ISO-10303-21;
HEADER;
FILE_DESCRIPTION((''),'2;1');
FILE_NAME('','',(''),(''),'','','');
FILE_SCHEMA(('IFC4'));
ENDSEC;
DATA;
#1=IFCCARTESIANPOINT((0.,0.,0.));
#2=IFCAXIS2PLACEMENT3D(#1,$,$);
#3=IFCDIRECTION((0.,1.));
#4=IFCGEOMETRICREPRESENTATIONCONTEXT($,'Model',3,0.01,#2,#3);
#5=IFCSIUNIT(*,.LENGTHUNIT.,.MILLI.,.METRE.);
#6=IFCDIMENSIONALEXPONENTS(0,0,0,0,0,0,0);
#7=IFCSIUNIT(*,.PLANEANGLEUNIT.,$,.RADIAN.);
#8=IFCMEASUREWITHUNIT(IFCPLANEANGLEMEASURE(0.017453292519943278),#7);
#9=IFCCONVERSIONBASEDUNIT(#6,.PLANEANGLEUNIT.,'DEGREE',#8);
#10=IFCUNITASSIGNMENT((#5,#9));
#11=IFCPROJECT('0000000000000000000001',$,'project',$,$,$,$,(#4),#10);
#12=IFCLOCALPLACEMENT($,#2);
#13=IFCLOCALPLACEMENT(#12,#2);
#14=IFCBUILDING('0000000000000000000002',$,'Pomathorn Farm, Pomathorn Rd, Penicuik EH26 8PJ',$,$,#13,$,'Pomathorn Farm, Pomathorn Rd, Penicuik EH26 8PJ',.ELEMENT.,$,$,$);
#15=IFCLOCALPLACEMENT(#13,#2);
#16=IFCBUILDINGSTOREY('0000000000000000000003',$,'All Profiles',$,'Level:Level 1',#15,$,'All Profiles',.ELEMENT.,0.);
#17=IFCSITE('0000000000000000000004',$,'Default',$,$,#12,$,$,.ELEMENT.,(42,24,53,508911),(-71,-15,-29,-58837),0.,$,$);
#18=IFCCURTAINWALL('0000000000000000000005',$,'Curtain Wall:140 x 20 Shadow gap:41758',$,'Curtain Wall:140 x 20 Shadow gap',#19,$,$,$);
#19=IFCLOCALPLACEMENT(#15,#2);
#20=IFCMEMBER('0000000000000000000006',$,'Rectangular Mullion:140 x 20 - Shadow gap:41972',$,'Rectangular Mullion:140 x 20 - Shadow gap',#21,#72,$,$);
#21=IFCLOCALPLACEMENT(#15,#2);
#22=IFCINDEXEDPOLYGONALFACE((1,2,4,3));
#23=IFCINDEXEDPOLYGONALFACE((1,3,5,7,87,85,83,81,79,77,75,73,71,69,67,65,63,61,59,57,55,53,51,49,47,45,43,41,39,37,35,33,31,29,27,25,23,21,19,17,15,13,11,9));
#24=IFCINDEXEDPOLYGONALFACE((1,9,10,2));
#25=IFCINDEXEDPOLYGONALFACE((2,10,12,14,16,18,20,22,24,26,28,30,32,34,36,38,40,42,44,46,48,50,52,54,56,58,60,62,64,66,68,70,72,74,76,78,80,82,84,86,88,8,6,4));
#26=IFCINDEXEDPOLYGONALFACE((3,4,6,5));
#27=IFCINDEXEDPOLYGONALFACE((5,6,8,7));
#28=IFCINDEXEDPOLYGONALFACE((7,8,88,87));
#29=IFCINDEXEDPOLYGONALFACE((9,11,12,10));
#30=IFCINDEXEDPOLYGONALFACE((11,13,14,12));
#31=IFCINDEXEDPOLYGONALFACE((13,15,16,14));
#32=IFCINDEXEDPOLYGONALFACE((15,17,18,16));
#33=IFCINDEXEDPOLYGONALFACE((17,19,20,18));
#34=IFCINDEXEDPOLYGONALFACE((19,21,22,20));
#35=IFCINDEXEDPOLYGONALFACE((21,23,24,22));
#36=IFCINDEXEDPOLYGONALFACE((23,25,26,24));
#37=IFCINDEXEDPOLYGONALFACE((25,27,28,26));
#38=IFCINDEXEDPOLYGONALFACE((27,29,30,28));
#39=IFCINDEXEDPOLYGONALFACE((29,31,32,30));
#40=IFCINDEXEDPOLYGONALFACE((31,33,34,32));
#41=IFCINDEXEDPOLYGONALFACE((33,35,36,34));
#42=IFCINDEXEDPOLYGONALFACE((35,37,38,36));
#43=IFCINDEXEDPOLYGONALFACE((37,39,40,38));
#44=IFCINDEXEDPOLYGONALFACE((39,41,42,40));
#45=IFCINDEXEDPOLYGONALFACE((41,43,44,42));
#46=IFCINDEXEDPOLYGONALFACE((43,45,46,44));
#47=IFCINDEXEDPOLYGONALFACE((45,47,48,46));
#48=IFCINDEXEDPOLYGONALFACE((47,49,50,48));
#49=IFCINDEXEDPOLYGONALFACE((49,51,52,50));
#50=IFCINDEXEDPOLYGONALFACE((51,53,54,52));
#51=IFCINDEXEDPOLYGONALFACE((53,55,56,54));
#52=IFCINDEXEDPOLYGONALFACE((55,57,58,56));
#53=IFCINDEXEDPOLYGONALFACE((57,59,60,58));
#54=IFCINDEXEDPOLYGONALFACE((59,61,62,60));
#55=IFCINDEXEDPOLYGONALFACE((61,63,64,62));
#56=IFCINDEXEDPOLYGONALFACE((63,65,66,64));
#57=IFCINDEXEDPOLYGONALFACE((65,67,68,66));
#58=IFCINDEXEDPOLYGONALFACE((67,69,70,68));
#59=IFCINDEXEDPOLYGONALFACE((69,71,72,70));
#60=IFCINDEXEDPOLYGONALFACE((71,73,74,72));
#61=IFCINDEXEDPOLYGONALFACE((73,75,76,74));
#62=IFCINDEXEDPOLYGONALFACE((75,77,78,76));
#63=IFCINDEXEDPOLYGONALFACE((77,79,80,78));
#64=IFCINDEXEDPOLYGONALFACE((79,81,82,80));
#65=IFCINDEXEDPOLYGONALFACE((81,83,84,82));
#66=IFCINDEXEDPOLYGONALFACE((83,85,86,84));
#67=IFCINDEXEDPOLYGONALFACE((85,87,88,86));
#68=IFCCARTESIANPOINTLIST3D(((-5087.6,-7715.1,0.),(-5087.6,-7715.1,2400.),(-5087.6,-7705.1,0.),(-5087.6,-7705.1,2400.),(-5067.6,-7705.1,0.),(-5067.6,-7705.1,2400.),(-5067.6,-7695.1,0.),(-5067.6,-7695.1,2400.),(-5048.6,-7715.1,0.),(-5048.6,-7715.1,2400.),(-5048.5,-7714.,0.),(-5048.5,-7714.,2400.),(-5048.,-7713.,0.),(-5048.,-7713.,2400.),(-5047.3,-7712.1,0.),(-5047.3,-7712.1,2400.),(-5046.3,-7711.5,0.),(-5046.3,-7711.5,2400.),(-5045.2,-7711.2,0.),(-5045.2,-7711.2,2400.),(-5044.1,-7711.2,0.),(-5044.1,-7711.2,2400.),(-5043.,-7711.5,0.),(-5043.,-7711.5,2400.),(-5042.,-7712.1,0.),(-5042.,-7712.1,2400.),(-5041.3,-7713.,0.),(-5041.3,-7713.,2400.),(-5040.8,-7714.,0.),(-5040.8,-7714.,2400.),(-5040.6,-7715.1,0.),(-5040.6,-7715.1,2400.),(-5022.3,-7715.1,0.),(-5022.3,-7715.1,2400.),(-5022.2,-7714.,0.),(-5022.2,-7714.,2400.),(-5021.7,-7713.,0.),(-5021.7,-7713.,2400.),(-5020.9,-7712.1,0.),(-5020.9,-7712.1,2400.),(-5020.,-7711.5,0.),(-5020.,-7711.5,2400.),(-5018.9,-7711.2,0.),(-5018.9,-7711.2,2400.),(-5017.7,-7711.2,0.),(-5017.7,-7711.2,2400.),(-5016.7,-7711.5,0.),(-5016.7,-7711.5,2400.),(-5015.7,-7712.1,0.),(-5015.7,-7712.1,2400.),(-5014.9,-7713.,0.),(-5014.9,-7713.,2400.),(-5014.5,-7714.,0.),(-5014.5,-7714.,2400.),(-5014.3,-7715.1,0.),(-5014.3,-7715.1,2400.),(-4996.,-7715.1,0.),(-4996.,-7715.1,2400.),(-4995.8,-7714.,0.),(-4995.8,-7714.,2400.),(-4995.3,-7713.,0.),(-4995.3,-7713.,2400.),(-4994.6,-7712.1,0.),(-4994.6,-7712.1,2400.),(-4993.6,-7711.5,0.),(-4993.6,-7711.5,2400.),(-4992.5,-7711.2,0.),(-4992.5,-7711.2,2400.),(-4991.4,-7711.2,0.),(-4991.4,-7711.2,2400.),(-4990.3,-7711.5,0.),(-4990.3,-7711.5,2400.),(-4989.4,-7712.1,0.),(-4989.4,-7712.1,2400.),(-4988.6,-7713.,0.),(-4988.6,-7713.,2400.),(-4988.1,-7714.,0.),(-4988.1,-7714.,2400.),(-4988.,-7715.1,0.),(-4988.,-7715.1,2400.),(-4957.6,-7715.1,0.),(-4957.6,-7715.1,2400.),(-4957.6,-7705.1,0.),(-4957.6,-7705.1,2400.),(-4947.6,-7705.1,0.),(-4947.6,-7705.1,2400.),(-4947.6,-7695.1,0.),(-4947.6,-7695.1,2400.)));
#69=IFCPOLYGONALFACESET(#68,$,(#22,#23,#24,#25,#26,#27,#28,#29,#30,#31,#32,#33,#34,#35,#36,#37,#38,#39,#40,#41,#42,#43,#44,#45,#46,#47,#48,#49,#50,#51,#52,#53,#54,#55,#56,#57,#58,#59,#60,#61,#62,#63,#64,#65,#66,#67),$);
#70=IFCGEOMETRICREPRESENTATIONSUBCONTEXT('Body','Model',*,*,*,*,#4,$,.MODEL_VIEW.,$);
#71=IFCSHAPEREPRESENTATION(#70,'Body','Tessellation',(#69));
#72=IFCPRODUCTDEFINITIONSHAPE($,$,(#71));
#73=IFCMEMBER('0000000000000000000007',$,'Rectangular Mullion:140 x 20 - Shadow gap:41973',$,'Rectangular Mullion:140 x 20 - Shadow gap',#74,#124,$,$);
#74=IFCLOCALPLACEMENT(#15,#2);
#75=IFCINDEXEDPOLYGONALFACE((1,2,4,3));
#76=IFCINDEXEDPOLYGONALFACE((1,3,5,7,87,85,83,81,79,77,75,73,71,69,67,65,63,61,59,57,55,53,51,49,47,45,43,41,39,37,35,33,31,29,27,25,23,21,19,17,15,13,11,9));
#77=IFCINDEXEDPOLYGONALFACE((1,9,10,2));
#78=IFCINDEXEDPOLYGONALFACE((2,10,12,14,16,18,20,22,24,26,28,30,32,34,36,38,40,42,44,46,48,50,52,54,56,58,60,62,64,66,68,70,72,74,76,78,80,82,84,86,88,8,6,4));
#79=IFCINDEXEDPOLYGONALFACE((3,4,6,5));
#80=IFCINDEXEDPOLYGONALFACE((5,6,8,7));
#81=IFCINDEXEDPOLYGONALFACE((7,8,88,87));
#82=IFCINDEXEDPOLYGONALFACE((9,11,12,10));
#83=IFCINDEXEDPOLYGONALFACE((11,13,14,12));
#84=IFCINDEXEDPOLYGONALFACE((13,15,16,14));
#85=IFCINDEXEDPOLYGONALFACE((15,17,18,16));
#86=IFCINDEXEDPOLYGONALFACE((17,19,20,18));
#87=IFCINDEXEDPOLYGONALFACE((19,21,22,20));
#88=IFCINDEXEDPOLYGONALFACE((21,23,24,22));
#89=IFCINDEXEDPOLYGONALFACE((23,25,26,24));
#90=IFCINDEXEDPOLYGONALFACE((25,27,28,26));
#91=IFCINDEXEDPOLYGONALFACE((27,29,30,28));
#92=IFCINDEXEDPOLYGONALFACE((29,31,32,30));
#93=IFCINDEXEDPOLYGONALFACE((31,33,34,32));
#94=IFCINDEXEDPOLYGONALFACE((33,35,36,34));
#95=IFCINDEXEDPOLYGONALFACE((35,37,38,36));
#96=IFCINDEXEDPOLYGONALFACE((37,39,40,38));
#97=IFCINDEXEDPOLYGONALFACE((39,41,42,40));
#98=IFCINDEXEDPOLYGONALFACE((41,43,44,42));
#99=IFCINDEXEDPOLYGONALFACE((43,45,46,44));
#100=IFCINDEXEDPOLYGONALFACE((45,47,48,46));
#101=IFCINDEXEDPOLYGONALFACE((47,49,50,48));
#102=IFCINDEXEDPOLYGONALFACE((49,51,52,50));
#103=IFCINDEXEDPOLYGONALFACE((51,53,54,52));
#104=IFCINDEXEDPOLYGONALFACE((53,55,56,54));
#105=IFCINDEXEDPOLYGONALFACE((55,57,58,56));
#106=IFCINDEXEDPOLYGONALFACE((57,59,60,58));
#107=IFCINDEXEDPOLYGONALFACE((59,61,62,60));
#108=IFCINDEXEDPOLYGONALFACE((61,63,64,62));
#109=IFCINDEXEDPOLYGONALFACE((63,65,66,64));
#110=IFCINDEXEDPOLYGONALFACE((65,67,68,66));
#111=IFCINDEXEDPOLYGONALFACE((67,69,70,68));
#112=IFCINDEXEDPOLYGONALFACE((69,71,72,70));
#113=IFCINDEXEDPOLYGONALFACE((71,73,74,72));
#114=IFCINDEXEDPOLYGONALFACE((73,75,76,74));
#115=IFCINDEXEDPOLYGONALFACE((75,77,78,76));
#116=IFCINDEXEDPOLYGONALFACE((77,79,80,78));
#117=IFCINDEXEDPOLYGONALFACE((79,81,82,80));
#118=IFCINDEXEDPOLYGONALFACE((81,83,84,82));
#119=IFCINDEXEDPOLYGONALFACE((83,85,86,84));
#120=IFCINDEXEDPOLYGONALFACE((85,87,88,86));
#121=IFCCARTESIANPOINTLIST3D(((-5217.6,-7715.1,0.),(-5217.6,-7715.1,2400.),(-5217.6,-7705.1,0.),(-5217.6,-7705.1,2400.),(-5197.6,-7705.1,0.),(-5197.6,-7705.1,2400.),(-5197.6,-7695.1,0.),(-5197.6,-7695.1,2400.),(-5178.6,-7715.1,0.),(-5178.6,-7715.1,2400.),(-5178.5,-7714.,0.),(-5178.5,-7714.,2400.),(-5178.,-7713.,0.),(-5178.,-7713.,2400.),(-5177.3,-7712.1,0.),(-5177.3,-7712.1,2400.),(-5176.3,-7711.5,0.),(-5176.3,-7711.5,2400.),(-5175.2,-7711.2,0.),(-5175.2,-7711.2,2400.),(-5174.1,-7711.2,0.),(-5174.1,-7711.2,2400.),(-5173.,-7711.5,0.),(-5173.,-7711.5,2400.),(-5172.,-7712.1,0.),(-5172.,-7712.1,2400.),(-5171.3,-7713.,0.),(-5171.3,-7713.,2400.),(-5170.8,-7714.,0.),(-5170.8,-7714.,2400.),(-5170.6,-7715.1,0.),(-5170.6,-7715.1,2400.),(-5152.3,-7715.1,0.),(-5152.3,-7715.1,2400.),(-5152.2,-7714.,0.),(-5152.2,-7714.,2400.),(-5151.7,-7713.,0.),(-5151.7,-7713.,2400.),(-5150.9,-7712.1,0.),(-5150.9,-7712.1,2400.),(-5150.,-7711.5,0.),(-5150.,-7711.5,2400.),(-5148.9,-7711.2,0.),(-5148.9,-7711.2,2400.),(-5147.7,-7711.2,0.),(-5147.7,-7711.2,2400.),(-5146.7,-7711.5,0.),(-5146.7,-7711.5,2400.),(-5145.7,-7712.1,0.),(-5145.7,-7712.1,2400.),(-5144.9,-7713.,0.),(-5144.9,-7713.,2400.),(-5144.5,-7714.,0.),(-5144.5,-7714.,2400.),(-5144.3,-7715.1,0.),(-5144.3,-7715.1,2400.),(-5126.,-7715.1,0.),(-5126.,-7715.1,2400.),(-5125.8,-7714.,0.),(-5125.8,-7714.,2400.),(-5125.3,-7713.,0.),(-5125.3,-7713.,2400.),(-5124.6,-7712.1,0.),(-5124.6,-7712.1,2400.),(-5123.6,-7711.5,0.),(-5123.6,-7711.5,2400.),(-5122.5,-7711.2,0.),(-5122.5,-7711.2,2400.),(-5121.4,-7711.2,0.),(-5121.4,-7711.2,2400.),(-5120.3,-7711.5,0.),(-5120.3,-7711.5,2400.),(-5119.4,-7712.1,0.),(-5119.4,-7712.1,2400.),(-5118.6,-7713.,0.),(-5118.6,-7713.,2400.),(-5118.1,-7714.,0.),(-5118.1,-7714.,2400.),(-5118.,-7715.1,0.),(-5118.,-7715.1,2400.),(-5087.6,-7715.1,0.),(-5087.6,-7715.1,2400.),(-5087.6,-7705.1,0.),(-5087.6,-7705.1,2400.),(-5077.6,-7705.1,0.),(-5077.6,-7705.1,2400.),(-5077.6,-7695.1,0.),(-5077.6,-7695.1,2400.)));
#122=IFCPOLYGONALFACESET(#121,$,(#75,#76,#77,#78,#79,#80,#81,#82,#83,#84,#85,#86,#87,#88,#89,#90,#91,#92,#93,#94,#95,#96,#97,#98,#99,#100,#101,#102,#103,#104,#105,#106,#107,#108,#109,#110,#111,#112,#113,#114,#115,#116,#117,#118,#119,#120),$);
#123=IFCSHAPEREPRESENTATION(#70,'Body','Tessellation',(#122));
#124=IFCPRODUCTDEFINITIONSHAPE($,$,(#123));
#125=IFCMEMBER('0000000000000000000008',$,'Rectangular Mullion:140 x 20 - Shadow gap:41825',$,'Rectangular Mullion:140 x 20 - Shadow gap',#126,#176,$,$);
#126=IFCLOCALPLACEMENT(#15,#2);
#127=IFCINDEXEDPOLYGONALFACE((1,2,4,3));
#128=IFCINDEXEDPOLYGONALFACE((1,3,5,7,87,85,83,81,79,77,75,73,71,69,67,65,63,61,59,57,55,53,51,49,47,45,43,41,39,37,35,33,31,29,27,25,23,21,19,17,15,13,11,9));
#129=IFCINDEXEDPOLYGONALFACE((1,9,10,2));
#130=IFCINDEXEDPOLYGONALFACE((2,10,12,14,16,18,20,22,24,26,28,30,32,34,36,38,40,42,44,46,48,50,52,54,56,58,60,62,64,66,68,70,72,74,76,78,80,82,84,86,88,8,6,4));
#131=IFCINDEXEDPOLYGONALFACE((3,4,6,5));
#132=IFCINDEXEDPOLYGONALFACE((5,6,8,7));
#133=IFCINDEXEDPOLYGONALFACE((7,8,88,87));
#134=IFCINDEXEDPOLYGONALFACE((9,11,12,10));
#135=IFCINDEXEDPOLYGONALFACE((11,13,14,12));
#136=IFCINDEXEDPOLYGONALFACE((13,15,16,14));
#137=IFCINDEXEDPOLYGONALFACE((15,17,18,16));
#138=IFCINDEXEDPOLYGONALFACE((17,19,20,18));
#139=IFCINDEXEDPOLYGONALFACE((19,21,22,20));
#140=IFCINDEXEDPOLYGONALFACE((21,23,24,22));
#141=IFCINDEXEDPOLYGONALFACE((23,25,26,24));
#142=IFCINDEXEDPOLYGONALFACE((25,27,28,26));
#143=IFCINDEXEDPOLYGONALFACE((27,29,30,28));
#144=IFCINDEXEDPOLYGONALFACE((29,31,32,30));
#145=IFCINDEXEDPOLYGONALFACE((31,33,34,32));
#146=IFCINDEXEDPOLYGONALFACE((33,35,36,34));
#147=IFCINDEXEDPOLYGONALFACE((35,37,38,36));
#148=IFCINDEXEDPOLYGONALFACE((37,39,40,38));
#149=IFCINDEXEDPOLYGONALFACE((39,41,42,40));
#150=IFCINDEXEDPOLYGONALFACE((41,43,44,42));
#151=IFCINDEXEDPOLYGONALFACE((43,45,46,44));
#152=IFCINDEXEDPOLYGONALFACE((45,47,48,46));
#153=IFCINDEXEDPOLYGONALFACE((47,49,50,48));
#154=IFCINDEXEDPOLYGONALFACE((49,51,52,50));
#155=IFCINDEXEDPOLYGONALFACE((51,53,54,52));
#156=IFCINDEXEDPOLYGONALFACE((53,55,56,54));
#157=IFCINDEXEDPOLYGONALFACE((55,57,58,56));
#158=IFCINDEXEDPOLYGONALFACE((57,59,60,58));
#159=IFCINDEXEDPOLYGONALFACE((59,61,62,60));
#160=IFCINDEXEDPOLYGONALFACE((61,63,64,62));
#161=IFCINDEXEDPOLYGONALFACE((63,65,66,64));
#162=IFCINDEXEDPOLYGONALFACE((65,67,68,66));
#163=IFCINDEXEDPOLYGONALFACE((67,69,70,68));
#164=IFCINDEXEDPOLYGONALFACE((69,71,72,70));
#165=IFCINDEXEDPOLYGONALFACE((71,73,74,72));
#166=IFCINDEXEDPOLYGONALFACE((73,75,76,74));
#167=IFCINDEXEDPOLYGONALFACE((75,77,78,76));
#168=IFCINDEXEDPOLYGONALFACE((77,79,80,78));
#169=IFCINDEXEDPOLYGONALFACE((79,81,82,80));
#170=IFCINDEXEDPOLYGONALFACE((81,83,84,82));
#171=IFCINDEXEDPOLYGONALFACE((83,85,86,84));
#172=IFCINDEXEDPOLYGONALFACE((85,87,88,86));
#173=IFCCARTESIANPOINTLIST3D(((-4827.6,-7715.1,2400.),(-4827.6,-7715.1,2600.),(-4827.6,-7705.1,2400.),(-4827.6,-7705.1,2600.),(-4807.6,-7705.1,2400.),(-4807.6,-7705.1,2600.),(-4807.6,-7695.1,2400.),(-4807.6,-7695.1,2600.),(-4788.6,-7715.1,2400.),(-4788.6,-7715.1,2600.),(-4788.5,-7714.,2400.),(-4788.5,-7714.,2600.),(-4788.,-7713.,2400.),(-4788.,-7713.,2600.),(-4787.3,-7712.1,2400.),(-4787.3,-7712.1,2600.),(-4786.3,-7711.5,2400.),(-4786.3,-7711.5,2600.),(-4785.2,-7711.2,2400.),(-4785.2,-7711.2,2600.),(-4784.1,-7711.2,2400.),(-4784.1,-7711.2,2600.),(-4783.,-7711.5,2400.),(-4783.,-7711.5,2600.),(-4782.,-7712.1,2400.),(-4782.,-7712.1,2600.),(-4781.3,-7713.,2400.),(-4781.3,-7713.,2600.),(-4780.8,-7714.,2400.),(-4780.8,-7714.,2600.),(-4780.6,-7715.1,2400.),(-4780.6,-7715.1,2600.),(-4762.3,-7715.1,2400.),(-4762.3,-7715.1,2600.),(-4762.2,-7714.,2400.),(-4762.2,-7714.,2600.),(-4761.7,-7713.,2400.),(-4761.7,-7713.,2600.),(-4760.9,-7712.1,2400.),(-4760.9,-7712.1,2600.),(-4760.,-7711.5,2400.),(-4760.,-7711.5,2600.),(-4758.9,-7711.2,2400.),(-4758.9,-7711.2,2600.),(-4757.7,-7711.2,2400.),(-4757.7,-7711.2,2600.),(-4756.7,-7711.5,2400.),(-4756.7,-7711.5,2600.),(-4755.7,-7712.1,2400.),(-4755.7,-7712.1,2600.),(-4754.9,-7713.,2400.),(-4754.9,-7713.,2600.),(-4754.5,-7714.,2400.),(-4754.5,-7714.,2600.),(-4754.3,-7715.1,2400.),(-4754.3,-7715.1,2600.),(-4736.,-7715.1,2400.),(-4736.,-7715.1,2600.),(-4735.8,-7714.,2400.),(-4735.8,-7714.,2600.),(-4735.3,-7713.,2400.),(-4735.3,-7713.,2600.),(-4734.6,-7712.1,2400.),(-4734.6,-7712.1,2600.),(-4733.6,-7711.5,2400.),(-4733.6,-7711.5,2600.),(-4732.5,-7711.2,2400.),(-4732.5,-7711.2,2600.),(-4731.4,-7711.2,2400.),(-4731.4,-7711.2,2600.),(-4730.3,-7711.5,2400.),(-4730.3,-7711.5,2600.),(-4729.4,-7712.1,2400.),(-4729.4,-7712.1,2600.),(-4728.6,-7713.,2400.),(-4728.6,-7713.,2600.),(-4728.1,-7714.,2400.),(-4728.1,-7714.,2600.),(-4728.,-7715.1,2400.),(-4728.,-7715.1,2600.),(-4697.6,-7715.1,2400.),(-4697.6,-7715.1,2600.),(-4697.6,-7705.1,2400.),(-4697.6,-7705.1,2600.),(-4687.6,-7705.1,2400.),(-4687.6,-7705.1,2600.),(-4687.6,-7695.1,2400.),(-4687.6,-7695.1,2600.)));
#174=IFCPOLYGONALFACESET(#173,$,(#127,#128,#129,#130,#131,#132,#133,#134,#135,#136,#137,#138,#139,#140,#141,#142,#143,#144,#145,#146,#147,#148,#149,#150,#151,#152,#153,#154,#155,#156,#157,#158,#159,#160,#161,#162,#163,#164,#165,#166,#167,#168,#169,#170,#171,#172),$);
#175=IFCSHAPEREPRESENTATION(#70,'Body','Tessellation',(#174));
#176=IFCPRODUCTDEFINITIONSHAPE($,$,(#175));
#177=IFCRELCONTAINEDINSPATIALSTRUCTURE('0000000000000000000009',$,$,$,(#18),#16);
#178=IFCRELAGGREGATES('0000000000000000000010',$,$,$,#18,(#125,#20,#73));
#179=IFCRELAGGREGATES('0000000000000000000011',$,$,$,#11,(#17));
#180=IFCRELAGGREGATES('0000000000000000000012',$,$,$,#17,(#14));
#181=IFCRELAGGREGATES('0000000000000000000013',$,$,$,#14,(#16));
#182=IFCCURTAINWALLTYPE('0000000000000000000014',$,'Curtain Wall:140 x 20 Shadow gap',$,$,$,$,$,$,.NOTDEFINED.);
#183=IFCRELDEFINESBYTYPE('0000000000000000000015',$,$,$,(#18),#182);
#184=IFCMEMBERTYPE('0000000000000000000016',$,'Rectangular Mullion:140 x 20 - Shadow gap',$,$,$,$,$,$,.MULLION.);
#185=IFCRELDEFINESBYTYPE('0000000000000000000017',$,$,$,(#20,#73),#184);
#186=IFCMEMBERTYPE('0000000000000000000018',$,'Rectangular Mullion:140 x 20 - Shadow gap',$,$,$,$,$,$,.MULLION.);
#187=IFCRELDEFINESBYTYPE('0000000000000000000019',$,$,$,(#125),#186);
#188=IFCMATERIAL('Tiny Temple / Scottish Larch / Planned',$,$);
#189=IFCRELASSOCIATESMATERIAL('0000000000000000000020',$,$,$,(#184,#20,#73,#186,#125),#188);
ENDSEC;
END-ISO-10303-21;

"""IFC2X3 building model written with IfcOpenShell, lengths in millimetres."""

from ifc_helpers import new_model, entity, si_unit, converted_unit, direction, frame, frame_2d, origin, place, context, subcontext, project, spatial, polyline, circle_curve, parameter, trimmed, segment, composite_curve, outline, extrude, source, transform, mapped, material, type_object, type_shapes, element, aggregate, save


model = new_model("IFC2X3")

# Units and contexts
model_context = context("Model", 3, precision=0.01, world=origin(), true_north=direction((0.0, 1.0)))
body_context = subcontext(model_context, "Body", "Model", "MODEL_VIEW")
ifc_project = project(units=[si_unit("LENGTHUNIT", "METRE", prefix="MILLI"), converted_unit("PLANEANGLEUNIT", "DEGREE", entity("IfcPlaneAngleMeasure", 0.017453292519943278), si_unit("PLANEANGLEUNIT", "RADIAN"), dimensions=[0, 0, 0, 0, 0, 0, 0])], contexts=[model_context])

# Site, building, storey
site_placement = place(None, origin())
site = spatial("IfcSite", under=ifc_project, at=site_placement, Name="Default", CompositionType="ELEMENT", RefLatitude=(42, 24, 53, 508911), RefLongitude=(-71, -15, -29, -58837), RefElevation=0.0)
building_placement = place(site_placement, origin())
building = spatial("IfcBuilding", under=site, at=building_placement, Name="Pomathorn Farm, Pomathorn Rd, Penicuik EH26 8PJ", LongName="Pomathorn Farm, Pomathorn Rd, Penicuik EH26 8PJ", CompositionType="ELEMENT")
storey_placement = place(building_placement, origin())
storey = spatial("IfcBuildingStorey", under=building, at=storey_placement, Name="All Profiles", ObjectType="Level:Level 1", LongName="All Profiles", CompositionType="ELEMENT", Elevation=0.0)

# Curtain wall, members
ifc_material = material(Name="Tiny Temple / Scottish Larch / Planned")
curtain_wall_type_1 = type_object("IfcCurtainWallType", Name="Curtain Wall:140 x 20 Shadow gap", PredefinedType="NOTDEFINED")
curtain_wall_1_placement = place(storey_placement, origin())
curtain_wall_1 = element("IfcCurtainWall", 1, at=curtain_wall_1_placement, inside=storey, type_object=curtain_wall_type_1, Name="Curtain Wall:140 x 20 Shadow gap:41758", ObjectType="Curtain Wall:140 x 20 Shadow gap")
member_type_1 = type_object("IfcMemberType", Name="Rectangular Mullion:140 x 20 - Shadow gap", PredefinedType="MULLION", material=ifc_material)
shared_shape_1 = source(origin(), body_context, "Body", "SweptSolid", [
    extrude(outline(composite_curve([segment(polyline([(28.5, -5.7), (58.9, -5.7)]), True, "CONTINUOUS"), segment(polyline([(58.9, -5.7), (58.9, 4.3)]), True, "CONTINUOUS"), segment(polyline([(58.9, 4.3), (68.9, 4.3)]), True, "CONTINUOUS"), segment(polyline([(68.9, 4.3), (68.9, 14.3)]), True, "CONTINUOUS"), segment(polyline([(68.9, 14.3), (-51.1, 14.3)]), True, "CONTINUOUS"), segment(polyline([(-51.1, 14.3), (-51.1, 4.3)]), True, "CONTINUOUS"), segment(polyline([(-51.1, 4.3), (-71.1, 4.3)]), True, "CONTINUOUS"), segment(polyline([(-71.1, 4.3), (-71.1, -5.7)]), True, "CONTINUOUS"), segment(polyline([(-71.1, -5.7), (-32.1, -5.7)]), True, "CONTINUOUS"), segment(trimmed(circle_curve(frame_2d((-28.1, -5.7), x_axis=(1.0, 0.0)), 4.0), [parameter(360.0)], [parameter(180.0)], True, "PARAMETER"), False, "CONTINUOUS"), segment(polyline([(-24.1, -5.7), (-5.8, -5.7)]), True, "CONTINUOUS"), segment(trimmed(circle_curve(frame_2d((-1.8, -5.7), x_axis=(1.0, 0.0)), 4.0), [parameter(360.0)], [parameter(180.0)], True, "PARAMETER"), False, "CONTINUOUS"), segment(polyline([(2.2, -5.7), (20.5, -5.7)]), True, "CONTINUOUS"), segment(trimmed(circle_curve(frame_2d((24.5, -5.7), x_axis=(1.0, 0.0)), 4.0), [parameter(360.0)], [parameter(180.0)], True, "PARAMETER"), False, "CONTINUOUS")], self_intersect=False)), frame((-68.9, -5.7, -2400.0), z_axis=(0.0, 0.0, -1.0), x_axis=(1.0, 0.0, 0.0)), (0.0, 0.0, -1.0), 2400.0),
])
type_shapes(member_type_1, [shared_shape_1])
member_1_placement = place(curtain_wall_1_placement, frame((-4947.6, -7715.1, 0.0), z_axis=(0.0, 0.0, -1.0), x_axis=(1.0, 0.0, 0.0)))
member_1 = element("IfcMember", 2, at=member_1_placement, type_object=member_type_1, material=ifc_material, Name="Rectangular Mullion:140 x 20 - Shadow gap:41972", ObjectType="Rectangular Mullion:140 x 20 - Shadow gap", context=body_context, shape_type="MappedRepresentation", body=[
    mapped(shared_shape_1, transform((0.0, 0.0, 0.0), scale=1.0)),
])
member_2_placement = place(curtain_wall_1_placement, frame((-5077.6, -7715.1, 0.0), z_axis=(0.0, 0.0, -1.0), x_axis=(1.0, 0.0, 0.0)))
member_2 = element("IfcMember", 3, at=member_2_placement, type_object=member_type_1, material=ifc_material, Name="Rectangular Mullion:140 x 20 - Shadow gap:41973", ObjectType="Rectangular Mullion:140 x 20 - Shadow gap", context=body_context, shape_type="MappedRepresentation", body=[
    mapped(shared_shape_1, transform((0.0, 0.0, 0.0), scale=1.0)),
])
member_type_2 = type_object("IfcMemberType", Name="Rectangular Mullion:140 x 20 - Shadow gap", PredefinedType="MULLION", material=ifc_material)
shared_shape_2 = source(origin(), body_context, "Body", "SweptSolid", [
    extrude(outline(composite_curve([segment(polyline([(28.5, -5.7), (58.9, -5.7)]), True, "CONTINUOUS"), segment(polyline([(58.9, -5.7), (58.9, 4.3)]), True, "CONTINUOUS"), segment(polyline([(58.9, 4.3), (68.9, 4.3)]), True, "CONTINUOUS"), segment(polyline([(68.9, 4.3), (68.9, 14.3)]), True, "CONTINUOUS"), segment(polyline([(68.9, 14.3), (-51.1, 14.3)]), True, "CONTINUOUS"), segment(polyline([(-51.1, 14.3), (-51.1, 4.3)]), True, "CONTINUOUS"), segment(polyline([(-51.1, 4.3), (-71.1, 4.3)]), True, "CONTINUOUS"), segment(polyline([(-71.1, 4.3), (-71.1, -5.7)]), True, "CONTINUOUS"), segment(polyline([(-71.1, -5.7), (-32.1, -5.7)]), True, "CONTINUOUS"), segment(trimmed(circle_curve(frame_2d((-28.1, -5.7), x_axis=(1.0, 0.0)), 4.0), [parameter(360.0)], [parameter(180.0)], True, "PARAMETER"), False, "CONTINUOUS"), segment(polyline([(-24.1, -5.7), (-5.8, -5.7)]), True, "CONTINUOUS"), segment(trimmed(circle_curve(frame_2d((-1.8, -5.7), x_axis=(1.0, 0.0)), 4.0), [parameter(360.0)], [parameter(180.0)], True, "PARAMETER"), False, "CONTINUOUS"), segment(polyline([(2.2, -5.7), (20.5, -5.7)]), True, "CONTINUOUS"), segment(trimmed(circle_curve(frame_2d((24.5, -5.7), x_axis=(1.0, 0.0)), 4.0), [parameter(360.0)], [parameter(180.0)], True, "PARAMETER"), False, "CONTINUOUS")], self_intersect=False)), frame((-68.9, -5.7, -200.0), z_axis=(0.0, 0.0, -1.0), x_axis=(1.0, 0.0, 0.0)), (0.0, 0.0, -1.0), 200.0),
])
type_shapes(member_type_2, [shared_shape_2])
member_3_placement = place(curtain_wall_1_placement, frame((-4687.6, -7715.1, 2400.0), z_axis=(0.0, 0.0, -1.0), x_axis=(1.0, 0.0, 0.0)))
member_3 = element("IfcMember", 4, at=member_3_placement, type_object=member_type_2, material=ifc_material, Name="Rectangular Mullion:140 x 20 - Shadow gap:41825", ObjectType="Rectangular Mullion:140 x 20 - Shadow gap", context=body_context, shape_type="MappedRepresentation", body=[
    mapped(shared_shape_2, transform((0.0, 0.0, 0.0), scale=1.0)),
])
aggregate(curtain_wall_1, [member_3, member_1, member_2])

save(model, "model.ifc")
